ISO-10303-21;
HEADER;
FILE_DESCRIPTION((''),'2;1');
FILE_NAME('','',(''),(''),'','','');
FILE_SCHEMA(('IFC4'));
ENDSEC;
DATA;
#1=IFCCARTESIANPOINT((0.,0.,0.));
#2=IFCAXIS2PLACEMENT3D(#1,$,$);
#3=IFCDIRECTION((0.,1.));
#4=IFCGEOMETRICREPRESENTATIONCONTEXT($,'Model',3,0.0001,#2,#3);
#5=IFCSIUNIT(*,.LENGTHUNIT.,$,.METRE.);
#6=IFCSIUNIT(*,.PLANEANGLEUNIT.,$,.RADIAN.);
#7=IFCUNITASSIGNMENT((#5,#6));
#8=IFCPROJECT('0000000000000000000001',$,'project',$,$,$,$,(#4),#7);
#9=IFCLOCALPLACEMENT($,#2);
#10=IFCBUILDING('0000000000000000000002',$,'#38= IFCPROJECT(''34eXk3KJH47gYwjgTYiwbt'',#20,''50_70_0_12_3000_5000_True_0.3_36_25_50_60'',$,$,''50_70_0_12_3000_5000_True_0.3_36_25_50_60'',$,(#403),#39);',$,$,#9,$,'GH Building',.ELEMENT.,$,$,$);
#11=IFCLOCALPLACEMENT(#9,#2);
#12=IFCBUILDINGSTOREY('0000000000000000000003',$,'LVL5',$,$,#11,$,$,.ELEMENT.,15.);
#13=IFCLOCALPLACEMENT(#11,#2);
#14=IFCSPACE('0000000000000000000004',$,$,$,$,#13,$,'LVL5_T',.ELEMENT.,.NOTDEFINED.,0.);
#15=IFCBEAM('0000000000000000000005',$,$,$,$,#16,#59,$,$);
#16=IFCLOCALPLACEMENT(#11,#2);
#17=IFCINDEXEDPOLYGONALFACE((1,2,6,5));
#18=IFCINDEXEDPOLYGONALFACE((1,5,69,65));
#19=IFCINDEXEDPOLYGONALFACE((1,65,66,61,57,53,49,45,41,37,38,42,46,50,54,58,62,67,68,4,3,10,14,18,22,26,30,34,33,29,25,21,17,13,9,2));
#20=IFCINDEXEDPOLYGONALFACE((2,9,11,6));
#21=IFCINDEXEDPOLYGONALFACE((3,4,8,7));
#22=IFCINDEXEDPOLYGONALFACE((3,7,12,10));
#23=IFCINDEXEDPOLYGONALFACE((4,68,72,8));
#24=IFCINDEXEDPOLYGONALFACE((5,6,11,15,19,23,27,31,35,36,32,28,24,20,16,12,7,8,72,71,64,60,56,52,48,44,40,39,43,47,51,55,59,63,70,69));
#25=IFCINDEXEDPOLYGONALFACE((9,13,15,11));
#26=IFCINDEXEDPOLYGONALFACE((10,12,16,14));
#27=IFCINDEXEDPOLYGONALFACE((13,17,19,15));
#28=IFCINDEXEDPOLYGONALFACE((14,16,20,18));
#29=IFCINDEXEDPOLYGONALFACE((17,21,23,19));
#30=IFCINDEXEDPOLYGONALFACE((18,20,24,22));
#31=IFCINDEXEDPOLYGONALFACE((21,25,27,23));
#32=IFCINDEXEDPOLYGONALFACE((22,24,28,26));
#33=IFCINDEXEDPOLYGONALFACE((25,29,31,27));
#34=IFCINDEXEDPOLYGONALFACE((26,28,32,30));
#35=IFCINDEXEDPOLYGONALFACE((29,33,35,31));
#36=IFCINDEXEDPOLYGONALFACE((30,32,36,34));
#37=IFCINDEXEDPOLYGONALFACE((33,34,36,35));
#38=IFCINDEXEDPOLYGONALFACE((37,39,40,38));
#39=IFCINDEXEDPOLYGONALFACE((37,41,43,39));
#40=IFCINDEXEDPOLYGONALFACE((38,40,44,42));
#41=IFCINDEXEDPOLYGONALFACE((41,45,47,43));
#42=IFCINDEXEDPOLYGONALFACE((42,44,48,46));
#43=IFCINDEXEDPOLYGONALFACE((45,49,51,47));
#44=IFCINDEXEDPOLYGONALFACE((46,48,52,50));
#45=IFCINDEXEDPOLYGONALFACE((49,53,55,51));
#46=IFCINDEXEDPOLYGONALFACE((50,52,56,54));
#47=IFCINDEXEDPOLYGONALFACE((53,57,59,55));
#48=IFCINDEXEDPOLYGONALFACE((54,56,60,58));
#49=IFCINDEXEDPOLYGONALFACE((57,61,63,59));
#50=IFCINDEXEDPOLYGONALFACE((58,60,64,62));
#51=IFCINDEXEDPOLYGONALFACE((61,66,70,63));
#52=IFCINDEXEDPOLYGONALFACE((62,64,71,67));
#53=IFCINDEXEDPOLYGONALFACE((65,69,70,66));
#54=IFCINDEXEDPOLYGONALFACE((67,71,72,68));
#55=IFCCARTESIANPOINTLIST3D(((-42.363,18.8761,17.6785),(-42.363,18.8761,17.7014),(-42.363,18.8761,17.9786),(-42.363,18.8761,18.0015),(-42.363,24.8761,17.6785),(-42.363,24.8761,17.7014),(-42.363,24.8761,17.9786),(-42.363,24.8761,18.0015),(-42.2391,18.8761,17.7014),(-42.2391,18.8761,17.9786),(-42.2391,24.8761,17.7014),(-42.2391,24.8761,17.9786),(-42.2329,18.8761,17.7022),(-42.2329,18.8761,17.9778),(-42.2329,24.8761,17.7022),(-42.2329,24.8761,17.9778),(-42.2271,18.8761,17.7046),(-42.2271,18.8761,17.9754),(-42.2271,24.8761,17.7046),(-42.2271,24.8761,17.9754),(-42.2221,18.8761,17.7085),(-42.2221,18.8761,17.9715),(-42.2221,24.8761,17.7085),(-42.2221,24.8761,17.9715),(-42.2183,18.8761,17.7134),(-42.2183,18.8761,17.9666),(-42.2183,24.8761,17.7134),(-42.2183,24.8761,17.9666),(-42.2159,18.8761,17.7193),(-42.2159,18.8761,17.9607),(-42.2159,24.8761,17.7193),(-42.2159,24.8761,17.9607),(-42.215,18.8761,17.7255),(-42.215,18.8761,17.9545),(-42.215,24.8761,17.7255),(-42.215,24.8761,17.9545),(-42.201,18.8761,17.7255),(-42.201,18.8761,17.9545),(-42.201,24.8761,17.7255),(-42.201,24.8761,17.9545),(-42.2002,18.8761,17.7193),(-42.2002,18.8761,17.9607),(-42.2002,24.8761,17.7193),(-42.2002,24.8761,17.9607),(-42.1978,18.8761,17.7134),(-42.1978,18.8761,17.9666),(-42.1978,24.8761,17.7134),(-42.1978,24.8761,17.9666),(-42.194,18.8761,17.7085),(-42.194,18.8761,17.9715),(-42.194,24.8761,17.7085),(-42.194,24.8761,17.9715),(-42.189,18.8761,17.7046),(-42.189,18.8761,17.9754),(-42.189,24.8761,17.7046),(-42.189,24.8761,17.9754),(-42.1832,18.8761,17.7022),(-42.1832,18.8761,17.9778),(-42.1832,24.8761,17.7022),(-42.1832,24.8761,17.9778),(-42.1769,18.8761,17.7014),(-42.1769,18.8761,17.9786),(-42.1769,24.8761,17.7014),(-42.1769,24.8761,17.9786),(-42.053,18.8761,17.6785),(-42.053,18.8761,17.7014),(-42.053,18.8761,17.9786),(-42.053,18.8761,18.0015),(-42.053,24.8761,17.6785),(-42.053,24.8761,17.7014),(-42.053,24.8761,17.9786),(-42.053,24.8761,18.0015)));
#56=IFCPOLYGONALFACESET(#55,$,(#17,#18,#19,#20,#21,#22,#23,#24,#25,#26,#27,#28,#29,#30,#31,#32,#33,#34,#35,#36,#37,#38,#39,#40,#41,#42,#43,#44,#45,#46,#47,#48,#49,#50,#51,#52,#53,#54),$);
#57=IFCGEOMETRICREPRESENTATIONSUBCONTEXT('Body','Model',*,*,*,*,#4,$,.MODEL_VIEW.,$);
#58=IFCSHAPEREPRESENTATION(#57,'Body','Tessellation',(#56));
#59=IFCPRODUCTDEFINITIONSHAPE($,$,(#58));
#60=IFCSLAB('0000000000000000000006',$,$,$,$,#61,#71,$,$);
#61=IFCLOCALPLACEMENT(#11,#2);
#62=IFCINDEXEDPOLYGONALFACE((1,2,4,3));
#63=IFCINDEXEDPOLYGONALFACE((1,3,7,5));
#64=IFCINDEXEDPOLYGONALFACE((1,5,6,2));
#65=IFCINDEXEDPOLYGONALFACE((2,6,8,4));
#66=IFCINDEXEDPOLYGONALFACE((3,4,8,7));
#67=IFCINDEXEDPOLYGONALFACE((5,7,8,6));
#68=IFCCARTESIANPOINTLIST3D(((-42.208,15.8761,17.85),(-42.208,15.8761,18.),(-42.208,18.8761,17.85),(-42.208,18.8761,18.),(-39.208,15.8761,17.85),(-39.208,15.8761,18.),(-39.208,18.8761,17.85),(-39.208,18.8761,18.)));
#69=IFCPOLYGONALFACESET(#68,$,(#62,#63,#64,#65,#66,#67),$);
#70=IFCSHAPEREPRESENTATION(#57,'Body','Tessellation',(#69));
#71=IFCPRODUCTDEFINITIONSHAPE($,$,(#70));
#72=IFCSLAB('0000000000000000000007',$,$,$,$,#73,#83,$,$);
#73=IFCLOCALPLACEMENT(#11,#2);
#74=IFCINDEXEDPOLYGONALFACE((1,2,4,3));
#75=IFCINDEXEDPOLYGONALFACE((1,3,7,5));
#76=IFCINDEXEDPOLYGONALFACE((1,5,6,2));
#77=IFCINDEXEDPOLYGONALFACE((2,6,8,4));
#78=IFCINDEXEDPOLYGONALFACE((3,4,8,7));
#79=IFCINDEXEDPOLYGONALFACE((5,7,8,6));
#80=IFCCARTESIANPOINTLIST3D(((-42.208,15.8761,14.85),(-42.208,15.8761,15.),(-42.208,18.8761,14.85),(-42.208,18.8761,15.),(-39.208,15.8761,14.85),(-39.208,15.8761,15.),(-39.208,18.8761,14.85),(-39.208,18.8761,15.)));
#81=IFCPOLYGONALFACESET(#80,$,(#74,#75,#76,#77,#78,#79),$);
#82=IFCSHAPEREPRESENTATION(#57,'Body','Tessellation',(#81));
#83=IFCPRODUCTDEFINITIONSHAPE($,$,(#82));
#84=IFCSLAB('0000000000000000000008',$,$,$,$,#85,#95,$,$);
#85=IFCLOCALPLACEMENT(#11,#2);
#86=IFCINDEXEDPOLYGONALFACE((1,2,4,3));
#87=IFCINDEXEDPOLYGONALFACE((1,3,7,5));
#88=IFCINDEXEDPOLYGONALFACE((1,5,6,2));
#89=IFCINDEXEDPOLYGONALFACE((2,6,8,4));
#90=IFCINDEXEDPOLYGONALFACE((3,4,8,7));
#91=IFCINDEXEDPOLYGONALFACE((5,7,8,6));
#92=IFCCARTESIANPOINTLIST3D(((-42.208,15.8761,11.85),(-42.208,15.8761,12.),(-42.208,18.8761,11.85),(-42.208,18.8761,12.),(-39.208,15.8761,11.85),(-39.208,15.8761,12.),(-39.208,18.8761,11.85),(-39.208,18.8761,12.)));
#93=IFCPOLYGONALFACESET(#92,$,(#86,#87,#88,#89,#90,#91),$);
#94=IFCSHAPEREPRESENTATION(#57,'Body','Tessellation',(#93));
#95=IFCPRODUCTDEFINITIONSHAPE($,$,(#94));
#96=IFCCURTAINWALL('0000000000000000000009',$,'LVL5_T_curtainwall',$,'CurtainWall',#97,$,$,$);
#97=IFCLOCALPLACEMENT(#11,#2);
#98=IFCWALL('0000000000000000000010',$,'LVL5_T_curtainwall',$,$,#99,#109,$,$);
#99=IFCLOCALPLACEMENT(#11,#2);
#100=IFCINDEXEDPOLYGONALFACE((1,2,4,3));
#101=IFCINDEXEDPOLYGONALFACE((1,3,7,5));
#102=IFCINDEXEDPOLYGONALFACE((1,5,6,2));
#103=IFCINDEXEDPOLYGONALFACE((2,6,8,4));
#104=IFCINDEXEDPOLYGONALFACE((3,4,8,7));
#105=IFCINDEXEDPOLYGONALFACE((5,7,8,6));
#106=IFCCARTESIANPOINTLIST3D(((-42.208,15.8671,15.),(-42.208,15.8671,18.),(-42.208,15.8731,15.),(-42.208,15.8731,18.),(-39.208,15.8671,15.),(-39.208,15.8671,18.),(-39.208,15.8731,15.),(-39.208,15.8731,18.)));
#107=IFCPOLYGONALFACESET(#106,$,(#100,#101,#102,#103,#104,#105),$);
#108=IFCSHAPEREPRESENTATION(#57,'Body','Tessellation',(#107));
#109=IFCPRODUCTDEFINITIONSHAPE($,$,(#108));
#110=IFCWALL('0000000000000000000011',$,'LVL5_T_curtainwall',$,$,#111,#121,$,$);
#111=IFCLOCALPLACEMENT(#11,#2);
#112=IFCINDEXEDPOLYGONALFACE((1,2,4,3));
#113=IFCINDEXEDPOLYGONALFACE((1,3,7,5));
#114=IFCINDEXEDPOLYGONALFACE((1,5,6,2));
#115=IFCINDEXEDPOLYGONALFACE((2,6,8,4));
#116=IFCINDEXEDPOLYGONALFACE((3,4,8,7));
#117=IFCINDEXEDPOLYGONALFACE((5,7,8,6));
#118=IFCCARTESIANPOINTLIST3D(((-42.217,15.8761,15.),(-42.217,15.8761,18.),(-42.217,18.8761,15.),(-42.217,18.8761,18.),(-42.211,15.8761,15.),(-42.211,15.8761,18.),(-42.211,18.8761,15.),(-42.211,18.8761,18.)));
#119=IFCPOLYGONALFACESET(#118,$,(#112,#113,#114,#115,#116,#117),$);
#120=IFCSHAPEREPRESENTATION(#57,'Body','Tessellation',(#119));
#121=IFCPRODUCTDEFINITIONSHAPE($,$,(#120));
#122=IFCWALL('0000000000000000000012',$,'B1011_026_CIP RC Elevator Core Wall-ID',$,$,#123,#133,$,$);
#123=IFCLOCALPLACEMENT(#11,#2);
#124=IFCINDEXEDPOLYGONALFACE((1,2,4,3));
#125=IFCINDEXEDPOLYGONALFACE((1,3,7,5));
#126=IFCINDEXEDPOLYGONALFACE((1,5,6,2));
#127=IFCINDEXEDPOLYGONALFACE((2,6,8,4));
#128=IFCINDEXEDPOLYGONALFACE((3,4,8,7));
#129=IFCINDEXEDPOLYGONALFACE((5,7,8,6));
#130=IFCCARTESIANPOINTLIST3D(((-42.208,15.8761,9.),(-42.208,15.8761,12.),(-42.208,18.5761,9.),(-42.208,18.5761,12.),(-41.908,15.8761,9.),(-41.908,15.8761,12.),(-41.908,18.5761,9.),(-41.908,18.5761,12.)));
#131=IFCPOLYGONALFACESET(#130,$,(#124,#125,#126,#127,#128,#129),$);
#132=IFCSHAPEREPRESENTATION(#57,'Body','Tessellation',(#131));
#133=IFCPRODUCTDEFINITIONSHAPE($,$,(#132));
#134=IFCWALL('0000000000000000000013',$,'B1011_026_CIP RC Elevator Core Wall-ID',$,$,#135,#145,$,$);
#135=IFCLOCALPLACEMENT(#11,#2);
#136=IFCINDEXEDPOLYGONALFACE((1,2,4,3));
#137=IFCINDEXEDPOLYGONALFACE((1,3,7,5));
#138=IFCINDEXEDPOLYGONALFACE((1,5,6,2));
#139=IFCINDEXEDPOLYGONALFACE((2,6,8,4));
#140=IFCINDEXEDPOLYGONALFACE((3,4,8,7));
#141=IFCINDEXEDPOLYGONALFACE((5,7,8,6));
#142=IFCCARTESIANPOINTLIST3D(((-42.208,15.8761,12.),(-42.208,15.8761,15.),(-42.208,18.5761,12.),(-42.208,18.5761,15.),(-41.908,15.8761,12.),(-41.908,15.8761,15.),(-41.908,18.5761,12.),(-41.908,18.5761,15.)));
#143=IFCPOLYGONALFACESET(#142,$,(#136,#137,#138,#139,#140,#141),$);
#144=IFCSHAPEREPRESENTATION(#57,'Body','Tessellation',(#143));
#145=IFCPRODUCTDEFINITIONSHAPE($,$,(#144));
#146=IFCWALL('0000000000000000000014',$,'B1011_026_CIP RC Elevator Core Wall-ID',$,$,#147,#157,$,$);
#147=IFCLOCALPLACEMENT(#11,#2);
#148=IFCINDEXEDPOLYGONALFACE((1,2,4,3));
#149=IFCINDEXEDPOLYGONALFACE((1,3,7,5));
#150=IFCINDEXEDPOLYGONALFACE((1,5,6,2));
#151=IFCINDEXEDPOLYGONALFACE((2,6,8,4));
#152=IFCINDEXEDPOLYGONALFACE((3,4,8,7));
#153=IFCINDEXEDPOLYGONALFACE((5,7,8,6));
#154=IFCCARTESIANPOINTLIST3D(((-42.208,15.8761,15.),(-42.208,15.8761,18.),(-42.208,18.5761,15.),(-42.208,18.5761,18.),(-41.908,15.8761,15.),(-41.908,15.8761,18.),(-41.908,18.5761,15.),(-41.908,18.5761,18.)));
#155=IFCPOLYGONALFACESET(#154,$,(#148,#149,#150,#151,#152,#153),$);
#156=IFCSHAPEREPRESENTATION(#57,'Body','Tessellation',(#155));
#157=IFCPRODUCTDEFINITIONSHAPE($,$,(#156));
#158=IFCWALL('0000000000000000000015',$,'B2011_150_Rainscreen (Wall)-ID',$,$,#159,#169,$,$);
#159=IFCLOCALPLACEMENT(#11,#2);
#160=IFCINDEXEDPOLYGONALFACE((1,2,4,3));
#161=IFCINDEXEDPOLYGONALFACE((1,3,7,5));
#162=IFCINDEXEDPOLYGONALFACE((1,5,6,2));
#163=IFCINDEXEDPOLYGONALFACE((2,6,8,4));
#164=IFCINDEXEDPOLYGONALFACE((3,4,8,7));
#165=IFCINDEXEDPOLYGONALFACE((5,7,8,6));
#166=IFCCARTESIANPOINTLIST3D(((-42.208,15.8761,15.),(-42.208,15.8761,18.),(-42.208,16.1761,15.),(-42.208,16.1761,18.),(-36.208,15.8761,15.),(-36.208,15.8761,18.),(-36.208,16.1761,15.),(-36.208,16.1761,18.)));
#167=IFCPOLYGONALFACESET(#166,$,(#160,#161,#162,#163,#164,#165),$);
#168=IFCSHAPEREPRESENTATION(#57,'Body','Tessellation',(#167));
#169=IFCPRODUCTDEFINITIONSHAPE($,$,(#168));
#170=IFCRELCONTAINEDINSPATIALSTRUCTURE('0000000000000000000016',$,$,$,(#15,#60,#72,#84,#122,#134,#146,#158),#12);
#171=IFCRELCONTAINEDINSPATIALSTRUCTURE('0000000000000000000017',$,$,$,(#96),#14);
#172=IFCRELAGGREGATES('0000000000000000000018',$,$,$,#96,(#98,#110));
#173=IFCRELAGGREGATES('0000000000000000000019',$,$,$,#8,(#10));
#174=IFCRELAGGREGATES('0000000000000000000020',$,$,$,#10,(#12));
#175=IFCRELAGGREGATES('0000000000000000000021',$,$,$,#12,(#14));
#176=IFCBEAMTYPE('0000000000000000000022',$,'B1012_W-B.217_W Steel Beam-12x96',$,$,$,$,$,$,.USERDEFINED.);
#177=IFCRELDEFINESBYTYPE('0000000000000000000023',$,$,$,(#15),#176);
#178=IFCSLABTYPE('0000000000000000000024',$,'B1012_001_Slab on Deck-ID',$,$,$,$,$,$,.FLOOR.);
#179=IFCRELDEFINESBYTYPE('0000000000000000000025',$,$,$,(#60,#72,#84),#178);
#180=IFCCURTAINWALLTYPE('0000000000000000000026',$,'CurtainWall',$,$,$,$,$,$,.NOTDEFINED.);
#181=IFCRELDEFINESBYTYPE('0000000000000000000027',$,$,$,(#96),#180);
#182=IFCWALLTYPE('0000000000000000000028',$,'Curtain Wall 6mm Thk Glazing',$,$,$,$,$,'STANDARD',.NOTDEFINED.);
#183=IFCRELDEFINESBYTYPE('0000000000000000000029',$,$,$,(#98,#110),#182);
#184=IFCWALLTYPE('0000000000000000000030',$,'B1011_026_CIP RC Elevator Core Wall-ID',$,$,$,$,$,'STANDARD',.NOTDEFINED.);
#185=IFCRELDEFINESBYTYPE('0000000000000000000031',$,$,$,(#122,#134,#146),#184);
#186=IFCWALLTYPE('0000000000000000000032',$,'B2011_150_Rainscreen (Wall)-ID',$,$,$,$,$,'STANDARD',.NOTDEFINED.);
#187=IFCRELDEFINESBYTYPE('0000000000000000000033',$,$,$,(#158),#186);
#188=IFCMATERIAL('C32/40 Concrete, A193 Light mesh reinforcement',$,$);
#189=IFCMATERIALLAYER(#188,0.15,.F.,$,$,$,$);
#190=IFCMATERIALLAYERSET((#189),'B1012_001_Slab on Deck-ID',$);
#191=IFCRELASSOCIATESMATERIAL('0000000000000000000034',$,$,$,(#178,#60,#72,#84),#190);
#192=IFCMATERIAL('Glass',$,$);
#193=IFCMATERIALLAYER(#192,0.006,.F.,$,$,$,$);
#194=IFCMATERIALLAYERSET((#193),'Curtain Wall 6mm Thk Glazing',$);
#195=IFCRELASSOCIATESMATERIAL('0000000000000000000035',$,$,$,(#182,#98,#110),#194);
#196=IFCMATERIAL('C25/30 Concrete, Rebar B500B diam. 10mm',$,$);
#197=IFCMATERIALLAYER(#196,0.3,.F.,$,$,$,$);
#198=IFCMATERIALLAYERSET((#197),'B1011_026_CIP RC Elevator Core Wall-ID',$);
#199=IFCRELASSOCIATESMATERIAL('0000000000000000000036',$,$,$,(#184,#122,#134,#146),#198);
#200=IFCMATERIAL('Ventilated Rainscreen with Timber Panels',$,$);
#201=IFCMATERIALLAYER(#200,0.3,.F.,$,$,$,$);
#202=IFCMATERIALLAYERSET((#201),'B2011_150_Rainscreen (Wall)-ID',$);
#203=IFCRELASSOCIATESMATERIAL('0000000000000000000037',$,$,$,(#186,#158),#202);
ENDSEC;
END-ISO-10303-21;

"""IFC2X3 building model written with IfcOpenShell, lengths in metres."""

from ifc_helpers import new_model, si_unit, direction, frame, frame_2d, origin, origin_2d, place, context, subcontext, project, spatial, polyline, rectangle, i_section, outline, extrude, material, layer, layer_set, layer_usage, type_object, element, aggregate, save


model = new_model("IFC2X3")

# Units and contexts
model_context = context("Model", 3, precision=0.0001, world=origin(), true_north=direction((0.0, 1.0)))
body_context = subcontext(model_context, "Body", "Model", "MODEL_VIEW")
ifc_project = project(units=[si_unit("LENGTHUNIT", "METRE"), si_unit("PLANEANGLEUNIT", "RADIAN")], contexts=[model_context])

# Building, storey, space
building_placement = place(None, origin())
building = spatial("IfcBuilding", under=ifc_project, at=building_placement, Name="#38= IFCPROJECT('34eXk3KJH47gYwjgTYiwbt',#20,'50_70_0_12_3000_5000_True_0.3_36_25_50_60',$,$,'50_70_0_12_3000_5000_True_0.3_36_25_50_60',$,(#403),#39);", LongName="GH Building", CompositionType="ELEMENT")
storey_placement = place(building_placement, origin())
storey = spatial("IfcBuildingStorey", under=building, at=storey_placement, Name="LVL5", CompositionType="ELEMENT", Elevation=15.0)
space_1_placement = place(storey_placement, origin())
space_1 = spatial("IfcSpace", under=storey, at=space_1_placement, LongName="LVL5_T", CompositionType="ELEMENT", InteriorOrExteriorSpace="NOTDEFINED", ElevationWithFlooring=0.0)

# Beam
beam_type = type_object("IfcBeamType", Name="B1012_W-B.217_W Steel Beam-12x96", PredefinedType="USERDEFINED")
for number, where, z_axis, x_axis in (
    (1, (-42.208, 18.8761, 17.84), (0.0, 1.0, 0.0), (-1.0, 0.0, 0.0)),
):
    element("IfcBeam", number, at=place(storey_placement, frame(where, z_axis=z_axis, x_axis=x_axis)), inside=storey, type_object=beam_type, context=body_context, shape_type="SweptSolid", body=[
        extrude(i_section(OverallWidth=0.31, OverallDepth=0.323, WebThickness=0.014, FlangeThickness=0.0229, FilletRadius=0.0241, at=origin_2d()), origin(), (0.0, 0.0, 1.0), 6.0),
    ])

# Slabs
ifc_material_1 = material(Name="C32/40 Concrete, A193 Light mesh reinforcement")
ifc_layer_1 = layer(ifc_material_1, 0.15, ventilated=False)
ifc_layer_set_1 = layer_set([ifc_layer_1], Name="B1012_001_Slab on Deck-ID")
ifc_layer_usage_1 = layer_usage(ifc_layer_set_1, "AXIS3", "NEGATIVE", -0.15)
slab_type = type_object("IfcSlabType", Name="B1012_001_Slab on Deck-ID", PredefinedType="FLOOR", material=ifc_layer_set_1)
slab_1_placement = place(storey_placement, frame((-40.708, 17.3761, 17.85)))
element("IfcSlab", 2, at=slab_1_placement, inside=storey, type_object=slab_type, material=ifc_layer_usage_1, context=body_context, shape_type="SweptSolid", body=[
    extrude(outline(polyline([(-1.5, -1.5), (-1.5, 1.5), (1.5, 1.5), (1.5, -1.5), (-1.5, -1.5)])), origin(), (0.0, 0.0, 1.0), 0.15),
])
ifc_layer_usage_2 = layer_usage(ifc_layer_set_1, "AXIS3", "NEGATIVE", -0.15)
slab_2_placement = place(storey_placement, frame((-40.708, 17.3761, 14.85)))
element("IfcSlab", 3, at=slab_2_placement, inside=storey, type_object=slab_type, material=ifc_layer_usage_2, context=body_context, shape_type="SweptSolid", body=[
    extrude(outline(polyline([(1.5, -1.5), (1.5, 1.5), (-1.5, 1.5), (-1.5, -1.5), (1.5, -1.5)])), origin(), (0.0, 0.0, 1.0), 0.15),
])
ifc_layer_usage_3 = layer_usage(ifc_layer_set_1, "AXIS3", "NEGATIVE", -0.15)
slab_3_placement = place(storey_placement, frame((-40.708, 17.3761, 11.85)))
element("IfcSlab", 4, at=slab_3_placement, inside=storey, type_object=slab_type, material=ifc_layer_usage_3, context=body_context, shape_type="SweptSolid", body=[
    extrude(outline(polyline([(-1.5, -1.5), (-1.5, 1.5), (1.5, 1.5), (1.5, -1.5), (-1.5, -1.5)])), origin(), (0.0, 0.0, 1.0), 0.15),
])

# Curtain wall, walls
curtain_wall_type = type_object("IfcCurtainWallType", Name="CurtainWall", PredefinedType="NOTDEFINED")
curtain_wall_1_placement = place(None, origin())
curtain_wall_1 = element("IfcCurtainWall", 5, at=curtain_wall_1_placement, inside=space_1, type_object=curtain_wall_type, Name="LVL5_T_curtainwall", ObjectType="CurtainWall")
ifc_material_2 = material(Name="Glass")
ifc_layer_2 = layer(ifc_material_2, 0.006, ventilated=False)
ifc_layer_set_2 = layer_set([ifc_layer_2], Name="Curtain Wall 6mm Thk Glazing")
ifc_layer_usage_4 = layer_usage(ifc_layer_set_2, "AXIS2", "NEGATIVE", -0.003)
wall_type_1 = type_object("IfcWallType", Name="Curtain Wall 6mm Thk Glazing", ElementType="STANDARD", PredefinedType="NOTDEFINED", material=ifc_layer_set_2)
wall_1_placement = place(curtain_wall_1_placement, frame((-42.208, 15.8761, 15.0)))
wall_1 = element("IfcWall", 6, at=wall_1_placement, type_object=wall_type_1, material=ifc_layer_usage_4, Name="LVL5_T_curtainwall", context=body_context, shape_type="SweptSolid", body=[
    extrude(rectangle(XDim=3.0, YDim=0.006, at=frame_2d((1.5, -0.006))), origin(), (0.0, 0.0, 1.0), 3.0),
])
ifc_layer_usage_5 = layer_usage(ifc_layer_set_2, "AXIS2", "NEGATIVE", -0.003)
wall_2_placement = place(curtain_wall_1_placement, frame((-42.208, 18.8761, 15.0), z_axis=(0.0, 0.0, 1.0), x_axis=(0.0, -1.0, 0.0)))
wall_2 = element("IfcWall", 7, at=wall_2_placement, type_object=wall_type_1, material=ifc_layer_usage_5, Name="LVL5_T_curtainwall", context=body_context, shape_type="SweptSolid", body=[
    extrude(rectangle(XDim=3.0, YDim=0.006, at=frame_2d((1.5, -0.006))), origin(), (0.0, 0.0, 1.0), 3.0),
])
aggregate(curtain_wall_1, [wall_1, wall_2])

# Walls
ifc_material_3 = material(Name="C25/30 Concrete, Rebar B500B diam. 10mm")
ifc_layer_3 = layer(ifc_material_3, 0.3, ventilated=False)
ifc_layer_set_3 = layer_set([ifc_layer_3], Name="B1011_026_CIP RC Elevator Core Wall-ID")
ifc_layer_usage_6 = layer_usage(ifc_layer_set_3, "AXIS2", "POSITIVE", 0.0)
wall_type_2 = type_object("IfcWallType", Name="B1011_026_CIP RC Elevator Core Wall-ID", ElementType="STANDARD", PredefinedType="NOTDEFINED", material=ifc_layer_set_3)
wall_3_placement = place(storey_placement, frame((-42.208, 18.5761, 9.0), z_axis=(0.0, 0.0, 1.0), x_axis=(0.0, -1.0, 0.0)))
element("IfcWall", 8, at=wall_3_placement, inside=storey, type_object=wall_type_2, material=ifc_layer_usage_6, Name="B1011_026_CIP RC Elevator Core Wall-ID", context=body_context, shape_type="SweptSolid", body=[
    extrude(rectangle(XDim=2.7, YDim=0.3, at=frame_2d((1.35, 0.15))), origin(), (0.0, 0.0, 1.0), 3.0),
])
ifc_layer_usage_7 = layer_usage(ifc_layer_set_3, "AXIS2", "POSITIVE", 0.0)
wall_4_placement = place(storey_placement, frame((-42.208, 18.5761, 12.0), z_axis=(0.0, 0.0, 1.0), x_axis=(0.0, -1.0, 0.0)))
element("IfcWall", 9, at=wall_4_placement, inside=storey, type_object=wall_type_2, material=ifc_layer_usage_7, Name="B1011_026_CIP RC Elevator Core Wall-ID", context=body_context, shape_type="SweptSolid", body=[
    extrude(rectangle(XDim=2.7, YDim=0.3, at=frame_2d((1.35, 0.15))), origin(), (0.0, 0.0, 1.0), 3.0),
])
ifc_layer_usage_8 = layer_usage(ifc_layer_set_3, "AXIS2", "POSITIVE", 0.0)
wall_5_placement = place(storey_placement, frame((-42.208, 18.5761, 15.0), z_axis=(0.0, 0.0, 1.0), x_axis=(0.0, -1.0, 0.0)))
element("IfcWall", 10, at=wall_5_placement, inside=storey, type_object=wall_type_2, material=ifc_layer_usage_8, Name="B1011_026_CIP RC Elevator Core Wall-ID", context=body_context, shape_type="SweptSolid", body=[
    extrude(rectangle(XDim=2.7, YDim=0.3, at=frame_2d((1.35, 0.15))), origin(), (0.0, 0.0, 1.0), 3.0),
])
ifc_material_4 = material(Name="Ventilated Rainscreen with Timber Panels")
ifc_layer_4 = layer(ifc_material_4, 0.3, ventilated=False)
ifc_layer_set_4 = layer_set([ifc_layer_4], Name="B2011_150_Rainscreen (Wall)-ID")
ifc_layer_usage_9 = layer_usage(ifc_layer_set_4, "AXIS2", "POSITIVE", 0.0)
wall_type_3 = type_object("IfcWallType", Name="B2011_150_Rainscreen (Wall)-ID", ElementType="STANDARD", PredefinedType="NOTDEFINED", material=ifc_layer_set_4)
wall_6_placement = place(storey_placement, frame((-42.208, 15.8761, 15.0)))
element("IfcWall", 11, at=wall_6_placement, inside=storey, type_object=wall_type_3, material=ifc_layer_usage_9, Name="B2011_150_Rainscreen (Wall)-ID", context=body_context, shape_type="SweptSolid", body=[
    extrude(rectangle(XDim=6.0, YDim=0.3, at=frame_2d((3.0, 0.15))), origin(), (0.0, 0.0, 1.0), 3.0),
])

save(model, "model.ifc")
